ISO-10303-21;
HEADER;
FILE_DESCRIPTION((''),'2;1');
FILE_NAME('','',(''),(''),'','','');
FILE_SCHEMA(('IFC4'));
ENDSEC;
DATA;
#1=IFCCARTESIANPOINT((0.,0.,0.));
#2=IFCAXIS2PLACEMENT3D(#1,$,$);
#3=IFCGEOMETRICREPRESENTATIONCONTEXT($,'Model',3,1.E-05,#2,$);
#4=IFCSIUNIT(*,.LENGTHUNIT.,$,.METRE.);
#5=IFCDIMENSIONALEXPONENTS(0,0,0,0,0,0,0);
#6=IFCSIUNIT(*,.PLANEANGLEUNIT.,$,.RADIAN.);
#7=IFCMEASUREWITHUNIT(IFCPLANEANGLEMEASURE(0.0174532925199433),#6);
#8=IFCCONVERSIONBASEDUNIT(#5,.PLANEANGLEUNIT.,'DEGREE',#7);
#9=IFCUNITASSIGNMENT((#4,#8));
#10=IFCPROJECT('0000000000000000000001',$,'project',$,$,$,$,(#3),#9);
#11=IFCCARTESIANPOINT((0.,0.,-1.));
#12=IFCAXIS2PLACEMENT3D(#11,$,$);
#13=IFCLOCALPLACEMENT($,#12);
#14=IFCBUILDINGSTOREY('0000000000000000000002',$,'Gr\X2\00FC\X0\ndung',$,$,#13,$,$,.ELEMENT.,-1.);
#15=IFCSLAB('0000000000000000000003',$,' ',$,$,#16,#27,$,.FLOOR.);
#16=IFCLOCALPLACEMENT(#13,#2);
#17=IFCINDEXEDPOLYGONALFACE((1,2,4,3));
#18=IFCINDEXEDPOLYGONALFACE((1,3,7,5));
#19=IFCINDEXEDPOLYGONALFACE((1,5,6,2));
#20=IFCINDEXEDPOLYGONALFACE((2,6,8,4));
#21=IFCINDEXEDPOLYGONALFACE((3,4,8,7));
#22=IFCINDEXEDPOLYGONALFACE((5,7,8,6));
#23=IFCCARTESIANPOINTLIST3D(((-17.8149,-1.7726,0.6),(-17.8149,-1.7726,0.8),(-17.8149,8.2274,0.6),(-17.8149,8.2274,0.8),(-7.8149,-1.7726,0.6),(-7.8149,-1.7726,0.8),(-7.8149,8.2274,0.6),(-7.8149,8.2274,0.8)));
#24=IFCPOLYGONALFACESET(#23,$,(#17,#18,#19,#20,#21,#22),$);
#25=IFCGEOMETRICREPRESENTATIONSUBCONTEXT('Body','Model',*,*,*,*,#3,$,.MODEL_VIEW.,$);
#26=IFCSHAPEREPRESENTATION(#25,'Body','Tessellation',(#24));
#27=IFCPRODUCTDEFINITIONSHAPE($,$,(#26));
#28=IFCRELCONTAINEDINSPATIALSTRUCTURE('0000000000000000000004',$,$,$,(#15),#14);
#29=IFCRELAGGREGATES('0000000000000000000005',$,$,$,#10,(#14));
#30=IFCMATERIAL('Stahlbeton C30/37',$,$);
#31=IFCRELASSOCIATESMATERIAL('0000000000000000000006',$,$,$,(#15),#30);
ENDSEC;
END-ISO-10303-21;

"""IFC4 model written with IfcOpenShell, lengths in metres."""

from ifc_helpers import new_model, entity, si_unit, converted_unit, frame, frame_2d, origin, place, context, subcontext, project, spatial, rectangle, extrude, material, element, save


model = new_model("IFC4")

# Units and contexts
model_context = context("Model", 3, precision=1e-05, world=origin())
body_context = subcontext(model_context, "Body", "Model", "MODEL_VIEW")
ifc_project = project(units=[si_unit("LENGTHUNIT", "METRE"), converted_unit("PLANEANGLEUNIT", "DEGREE", entity("IfcPlaneAngleMeasure", 0.0174532925199433), si_unit("PLANEANGLEUNIT", "RADIAN"), dimensions=[0, 0, 0, 0, 0, 0, 0])], contexts=[model_context])

# Storey
storey_placement = place(None, frame((0.0, 0.0, -1.0)))
storey = spatial("IfcBuildingStorey", under=ifc_project, at=storey_placement, Name="Gründung", CompositionType="ELEMENT", Elevation=-1.0)

# Slab
ifc_material = material(Name="Stahlbeton C30/37")
slab_placement = place(storey_placement, frame((-17.8149, -1.7726, 0.6)))
element("IfcSlab", 1, at=slab_placement, inside=storey, material=ifc_material, Name=" ", PredefinedType="FLOOR", context=body_context, shape_type="SweptSolid", body=[
    extrude(rectangle(XDim=10.0, YDim=10.0, at=frame_2d((5.0, -5.0), x_axis=(0.0, -1.0))), frame((0.0, 10.0, 0.0), z_axis=(0.0, 0.0, 1.0), x_axis=(1.0, 0.0, 0.0)), (0.0, 0.0, 1.0), 0.2),
])

save(model, "model.ifc")
